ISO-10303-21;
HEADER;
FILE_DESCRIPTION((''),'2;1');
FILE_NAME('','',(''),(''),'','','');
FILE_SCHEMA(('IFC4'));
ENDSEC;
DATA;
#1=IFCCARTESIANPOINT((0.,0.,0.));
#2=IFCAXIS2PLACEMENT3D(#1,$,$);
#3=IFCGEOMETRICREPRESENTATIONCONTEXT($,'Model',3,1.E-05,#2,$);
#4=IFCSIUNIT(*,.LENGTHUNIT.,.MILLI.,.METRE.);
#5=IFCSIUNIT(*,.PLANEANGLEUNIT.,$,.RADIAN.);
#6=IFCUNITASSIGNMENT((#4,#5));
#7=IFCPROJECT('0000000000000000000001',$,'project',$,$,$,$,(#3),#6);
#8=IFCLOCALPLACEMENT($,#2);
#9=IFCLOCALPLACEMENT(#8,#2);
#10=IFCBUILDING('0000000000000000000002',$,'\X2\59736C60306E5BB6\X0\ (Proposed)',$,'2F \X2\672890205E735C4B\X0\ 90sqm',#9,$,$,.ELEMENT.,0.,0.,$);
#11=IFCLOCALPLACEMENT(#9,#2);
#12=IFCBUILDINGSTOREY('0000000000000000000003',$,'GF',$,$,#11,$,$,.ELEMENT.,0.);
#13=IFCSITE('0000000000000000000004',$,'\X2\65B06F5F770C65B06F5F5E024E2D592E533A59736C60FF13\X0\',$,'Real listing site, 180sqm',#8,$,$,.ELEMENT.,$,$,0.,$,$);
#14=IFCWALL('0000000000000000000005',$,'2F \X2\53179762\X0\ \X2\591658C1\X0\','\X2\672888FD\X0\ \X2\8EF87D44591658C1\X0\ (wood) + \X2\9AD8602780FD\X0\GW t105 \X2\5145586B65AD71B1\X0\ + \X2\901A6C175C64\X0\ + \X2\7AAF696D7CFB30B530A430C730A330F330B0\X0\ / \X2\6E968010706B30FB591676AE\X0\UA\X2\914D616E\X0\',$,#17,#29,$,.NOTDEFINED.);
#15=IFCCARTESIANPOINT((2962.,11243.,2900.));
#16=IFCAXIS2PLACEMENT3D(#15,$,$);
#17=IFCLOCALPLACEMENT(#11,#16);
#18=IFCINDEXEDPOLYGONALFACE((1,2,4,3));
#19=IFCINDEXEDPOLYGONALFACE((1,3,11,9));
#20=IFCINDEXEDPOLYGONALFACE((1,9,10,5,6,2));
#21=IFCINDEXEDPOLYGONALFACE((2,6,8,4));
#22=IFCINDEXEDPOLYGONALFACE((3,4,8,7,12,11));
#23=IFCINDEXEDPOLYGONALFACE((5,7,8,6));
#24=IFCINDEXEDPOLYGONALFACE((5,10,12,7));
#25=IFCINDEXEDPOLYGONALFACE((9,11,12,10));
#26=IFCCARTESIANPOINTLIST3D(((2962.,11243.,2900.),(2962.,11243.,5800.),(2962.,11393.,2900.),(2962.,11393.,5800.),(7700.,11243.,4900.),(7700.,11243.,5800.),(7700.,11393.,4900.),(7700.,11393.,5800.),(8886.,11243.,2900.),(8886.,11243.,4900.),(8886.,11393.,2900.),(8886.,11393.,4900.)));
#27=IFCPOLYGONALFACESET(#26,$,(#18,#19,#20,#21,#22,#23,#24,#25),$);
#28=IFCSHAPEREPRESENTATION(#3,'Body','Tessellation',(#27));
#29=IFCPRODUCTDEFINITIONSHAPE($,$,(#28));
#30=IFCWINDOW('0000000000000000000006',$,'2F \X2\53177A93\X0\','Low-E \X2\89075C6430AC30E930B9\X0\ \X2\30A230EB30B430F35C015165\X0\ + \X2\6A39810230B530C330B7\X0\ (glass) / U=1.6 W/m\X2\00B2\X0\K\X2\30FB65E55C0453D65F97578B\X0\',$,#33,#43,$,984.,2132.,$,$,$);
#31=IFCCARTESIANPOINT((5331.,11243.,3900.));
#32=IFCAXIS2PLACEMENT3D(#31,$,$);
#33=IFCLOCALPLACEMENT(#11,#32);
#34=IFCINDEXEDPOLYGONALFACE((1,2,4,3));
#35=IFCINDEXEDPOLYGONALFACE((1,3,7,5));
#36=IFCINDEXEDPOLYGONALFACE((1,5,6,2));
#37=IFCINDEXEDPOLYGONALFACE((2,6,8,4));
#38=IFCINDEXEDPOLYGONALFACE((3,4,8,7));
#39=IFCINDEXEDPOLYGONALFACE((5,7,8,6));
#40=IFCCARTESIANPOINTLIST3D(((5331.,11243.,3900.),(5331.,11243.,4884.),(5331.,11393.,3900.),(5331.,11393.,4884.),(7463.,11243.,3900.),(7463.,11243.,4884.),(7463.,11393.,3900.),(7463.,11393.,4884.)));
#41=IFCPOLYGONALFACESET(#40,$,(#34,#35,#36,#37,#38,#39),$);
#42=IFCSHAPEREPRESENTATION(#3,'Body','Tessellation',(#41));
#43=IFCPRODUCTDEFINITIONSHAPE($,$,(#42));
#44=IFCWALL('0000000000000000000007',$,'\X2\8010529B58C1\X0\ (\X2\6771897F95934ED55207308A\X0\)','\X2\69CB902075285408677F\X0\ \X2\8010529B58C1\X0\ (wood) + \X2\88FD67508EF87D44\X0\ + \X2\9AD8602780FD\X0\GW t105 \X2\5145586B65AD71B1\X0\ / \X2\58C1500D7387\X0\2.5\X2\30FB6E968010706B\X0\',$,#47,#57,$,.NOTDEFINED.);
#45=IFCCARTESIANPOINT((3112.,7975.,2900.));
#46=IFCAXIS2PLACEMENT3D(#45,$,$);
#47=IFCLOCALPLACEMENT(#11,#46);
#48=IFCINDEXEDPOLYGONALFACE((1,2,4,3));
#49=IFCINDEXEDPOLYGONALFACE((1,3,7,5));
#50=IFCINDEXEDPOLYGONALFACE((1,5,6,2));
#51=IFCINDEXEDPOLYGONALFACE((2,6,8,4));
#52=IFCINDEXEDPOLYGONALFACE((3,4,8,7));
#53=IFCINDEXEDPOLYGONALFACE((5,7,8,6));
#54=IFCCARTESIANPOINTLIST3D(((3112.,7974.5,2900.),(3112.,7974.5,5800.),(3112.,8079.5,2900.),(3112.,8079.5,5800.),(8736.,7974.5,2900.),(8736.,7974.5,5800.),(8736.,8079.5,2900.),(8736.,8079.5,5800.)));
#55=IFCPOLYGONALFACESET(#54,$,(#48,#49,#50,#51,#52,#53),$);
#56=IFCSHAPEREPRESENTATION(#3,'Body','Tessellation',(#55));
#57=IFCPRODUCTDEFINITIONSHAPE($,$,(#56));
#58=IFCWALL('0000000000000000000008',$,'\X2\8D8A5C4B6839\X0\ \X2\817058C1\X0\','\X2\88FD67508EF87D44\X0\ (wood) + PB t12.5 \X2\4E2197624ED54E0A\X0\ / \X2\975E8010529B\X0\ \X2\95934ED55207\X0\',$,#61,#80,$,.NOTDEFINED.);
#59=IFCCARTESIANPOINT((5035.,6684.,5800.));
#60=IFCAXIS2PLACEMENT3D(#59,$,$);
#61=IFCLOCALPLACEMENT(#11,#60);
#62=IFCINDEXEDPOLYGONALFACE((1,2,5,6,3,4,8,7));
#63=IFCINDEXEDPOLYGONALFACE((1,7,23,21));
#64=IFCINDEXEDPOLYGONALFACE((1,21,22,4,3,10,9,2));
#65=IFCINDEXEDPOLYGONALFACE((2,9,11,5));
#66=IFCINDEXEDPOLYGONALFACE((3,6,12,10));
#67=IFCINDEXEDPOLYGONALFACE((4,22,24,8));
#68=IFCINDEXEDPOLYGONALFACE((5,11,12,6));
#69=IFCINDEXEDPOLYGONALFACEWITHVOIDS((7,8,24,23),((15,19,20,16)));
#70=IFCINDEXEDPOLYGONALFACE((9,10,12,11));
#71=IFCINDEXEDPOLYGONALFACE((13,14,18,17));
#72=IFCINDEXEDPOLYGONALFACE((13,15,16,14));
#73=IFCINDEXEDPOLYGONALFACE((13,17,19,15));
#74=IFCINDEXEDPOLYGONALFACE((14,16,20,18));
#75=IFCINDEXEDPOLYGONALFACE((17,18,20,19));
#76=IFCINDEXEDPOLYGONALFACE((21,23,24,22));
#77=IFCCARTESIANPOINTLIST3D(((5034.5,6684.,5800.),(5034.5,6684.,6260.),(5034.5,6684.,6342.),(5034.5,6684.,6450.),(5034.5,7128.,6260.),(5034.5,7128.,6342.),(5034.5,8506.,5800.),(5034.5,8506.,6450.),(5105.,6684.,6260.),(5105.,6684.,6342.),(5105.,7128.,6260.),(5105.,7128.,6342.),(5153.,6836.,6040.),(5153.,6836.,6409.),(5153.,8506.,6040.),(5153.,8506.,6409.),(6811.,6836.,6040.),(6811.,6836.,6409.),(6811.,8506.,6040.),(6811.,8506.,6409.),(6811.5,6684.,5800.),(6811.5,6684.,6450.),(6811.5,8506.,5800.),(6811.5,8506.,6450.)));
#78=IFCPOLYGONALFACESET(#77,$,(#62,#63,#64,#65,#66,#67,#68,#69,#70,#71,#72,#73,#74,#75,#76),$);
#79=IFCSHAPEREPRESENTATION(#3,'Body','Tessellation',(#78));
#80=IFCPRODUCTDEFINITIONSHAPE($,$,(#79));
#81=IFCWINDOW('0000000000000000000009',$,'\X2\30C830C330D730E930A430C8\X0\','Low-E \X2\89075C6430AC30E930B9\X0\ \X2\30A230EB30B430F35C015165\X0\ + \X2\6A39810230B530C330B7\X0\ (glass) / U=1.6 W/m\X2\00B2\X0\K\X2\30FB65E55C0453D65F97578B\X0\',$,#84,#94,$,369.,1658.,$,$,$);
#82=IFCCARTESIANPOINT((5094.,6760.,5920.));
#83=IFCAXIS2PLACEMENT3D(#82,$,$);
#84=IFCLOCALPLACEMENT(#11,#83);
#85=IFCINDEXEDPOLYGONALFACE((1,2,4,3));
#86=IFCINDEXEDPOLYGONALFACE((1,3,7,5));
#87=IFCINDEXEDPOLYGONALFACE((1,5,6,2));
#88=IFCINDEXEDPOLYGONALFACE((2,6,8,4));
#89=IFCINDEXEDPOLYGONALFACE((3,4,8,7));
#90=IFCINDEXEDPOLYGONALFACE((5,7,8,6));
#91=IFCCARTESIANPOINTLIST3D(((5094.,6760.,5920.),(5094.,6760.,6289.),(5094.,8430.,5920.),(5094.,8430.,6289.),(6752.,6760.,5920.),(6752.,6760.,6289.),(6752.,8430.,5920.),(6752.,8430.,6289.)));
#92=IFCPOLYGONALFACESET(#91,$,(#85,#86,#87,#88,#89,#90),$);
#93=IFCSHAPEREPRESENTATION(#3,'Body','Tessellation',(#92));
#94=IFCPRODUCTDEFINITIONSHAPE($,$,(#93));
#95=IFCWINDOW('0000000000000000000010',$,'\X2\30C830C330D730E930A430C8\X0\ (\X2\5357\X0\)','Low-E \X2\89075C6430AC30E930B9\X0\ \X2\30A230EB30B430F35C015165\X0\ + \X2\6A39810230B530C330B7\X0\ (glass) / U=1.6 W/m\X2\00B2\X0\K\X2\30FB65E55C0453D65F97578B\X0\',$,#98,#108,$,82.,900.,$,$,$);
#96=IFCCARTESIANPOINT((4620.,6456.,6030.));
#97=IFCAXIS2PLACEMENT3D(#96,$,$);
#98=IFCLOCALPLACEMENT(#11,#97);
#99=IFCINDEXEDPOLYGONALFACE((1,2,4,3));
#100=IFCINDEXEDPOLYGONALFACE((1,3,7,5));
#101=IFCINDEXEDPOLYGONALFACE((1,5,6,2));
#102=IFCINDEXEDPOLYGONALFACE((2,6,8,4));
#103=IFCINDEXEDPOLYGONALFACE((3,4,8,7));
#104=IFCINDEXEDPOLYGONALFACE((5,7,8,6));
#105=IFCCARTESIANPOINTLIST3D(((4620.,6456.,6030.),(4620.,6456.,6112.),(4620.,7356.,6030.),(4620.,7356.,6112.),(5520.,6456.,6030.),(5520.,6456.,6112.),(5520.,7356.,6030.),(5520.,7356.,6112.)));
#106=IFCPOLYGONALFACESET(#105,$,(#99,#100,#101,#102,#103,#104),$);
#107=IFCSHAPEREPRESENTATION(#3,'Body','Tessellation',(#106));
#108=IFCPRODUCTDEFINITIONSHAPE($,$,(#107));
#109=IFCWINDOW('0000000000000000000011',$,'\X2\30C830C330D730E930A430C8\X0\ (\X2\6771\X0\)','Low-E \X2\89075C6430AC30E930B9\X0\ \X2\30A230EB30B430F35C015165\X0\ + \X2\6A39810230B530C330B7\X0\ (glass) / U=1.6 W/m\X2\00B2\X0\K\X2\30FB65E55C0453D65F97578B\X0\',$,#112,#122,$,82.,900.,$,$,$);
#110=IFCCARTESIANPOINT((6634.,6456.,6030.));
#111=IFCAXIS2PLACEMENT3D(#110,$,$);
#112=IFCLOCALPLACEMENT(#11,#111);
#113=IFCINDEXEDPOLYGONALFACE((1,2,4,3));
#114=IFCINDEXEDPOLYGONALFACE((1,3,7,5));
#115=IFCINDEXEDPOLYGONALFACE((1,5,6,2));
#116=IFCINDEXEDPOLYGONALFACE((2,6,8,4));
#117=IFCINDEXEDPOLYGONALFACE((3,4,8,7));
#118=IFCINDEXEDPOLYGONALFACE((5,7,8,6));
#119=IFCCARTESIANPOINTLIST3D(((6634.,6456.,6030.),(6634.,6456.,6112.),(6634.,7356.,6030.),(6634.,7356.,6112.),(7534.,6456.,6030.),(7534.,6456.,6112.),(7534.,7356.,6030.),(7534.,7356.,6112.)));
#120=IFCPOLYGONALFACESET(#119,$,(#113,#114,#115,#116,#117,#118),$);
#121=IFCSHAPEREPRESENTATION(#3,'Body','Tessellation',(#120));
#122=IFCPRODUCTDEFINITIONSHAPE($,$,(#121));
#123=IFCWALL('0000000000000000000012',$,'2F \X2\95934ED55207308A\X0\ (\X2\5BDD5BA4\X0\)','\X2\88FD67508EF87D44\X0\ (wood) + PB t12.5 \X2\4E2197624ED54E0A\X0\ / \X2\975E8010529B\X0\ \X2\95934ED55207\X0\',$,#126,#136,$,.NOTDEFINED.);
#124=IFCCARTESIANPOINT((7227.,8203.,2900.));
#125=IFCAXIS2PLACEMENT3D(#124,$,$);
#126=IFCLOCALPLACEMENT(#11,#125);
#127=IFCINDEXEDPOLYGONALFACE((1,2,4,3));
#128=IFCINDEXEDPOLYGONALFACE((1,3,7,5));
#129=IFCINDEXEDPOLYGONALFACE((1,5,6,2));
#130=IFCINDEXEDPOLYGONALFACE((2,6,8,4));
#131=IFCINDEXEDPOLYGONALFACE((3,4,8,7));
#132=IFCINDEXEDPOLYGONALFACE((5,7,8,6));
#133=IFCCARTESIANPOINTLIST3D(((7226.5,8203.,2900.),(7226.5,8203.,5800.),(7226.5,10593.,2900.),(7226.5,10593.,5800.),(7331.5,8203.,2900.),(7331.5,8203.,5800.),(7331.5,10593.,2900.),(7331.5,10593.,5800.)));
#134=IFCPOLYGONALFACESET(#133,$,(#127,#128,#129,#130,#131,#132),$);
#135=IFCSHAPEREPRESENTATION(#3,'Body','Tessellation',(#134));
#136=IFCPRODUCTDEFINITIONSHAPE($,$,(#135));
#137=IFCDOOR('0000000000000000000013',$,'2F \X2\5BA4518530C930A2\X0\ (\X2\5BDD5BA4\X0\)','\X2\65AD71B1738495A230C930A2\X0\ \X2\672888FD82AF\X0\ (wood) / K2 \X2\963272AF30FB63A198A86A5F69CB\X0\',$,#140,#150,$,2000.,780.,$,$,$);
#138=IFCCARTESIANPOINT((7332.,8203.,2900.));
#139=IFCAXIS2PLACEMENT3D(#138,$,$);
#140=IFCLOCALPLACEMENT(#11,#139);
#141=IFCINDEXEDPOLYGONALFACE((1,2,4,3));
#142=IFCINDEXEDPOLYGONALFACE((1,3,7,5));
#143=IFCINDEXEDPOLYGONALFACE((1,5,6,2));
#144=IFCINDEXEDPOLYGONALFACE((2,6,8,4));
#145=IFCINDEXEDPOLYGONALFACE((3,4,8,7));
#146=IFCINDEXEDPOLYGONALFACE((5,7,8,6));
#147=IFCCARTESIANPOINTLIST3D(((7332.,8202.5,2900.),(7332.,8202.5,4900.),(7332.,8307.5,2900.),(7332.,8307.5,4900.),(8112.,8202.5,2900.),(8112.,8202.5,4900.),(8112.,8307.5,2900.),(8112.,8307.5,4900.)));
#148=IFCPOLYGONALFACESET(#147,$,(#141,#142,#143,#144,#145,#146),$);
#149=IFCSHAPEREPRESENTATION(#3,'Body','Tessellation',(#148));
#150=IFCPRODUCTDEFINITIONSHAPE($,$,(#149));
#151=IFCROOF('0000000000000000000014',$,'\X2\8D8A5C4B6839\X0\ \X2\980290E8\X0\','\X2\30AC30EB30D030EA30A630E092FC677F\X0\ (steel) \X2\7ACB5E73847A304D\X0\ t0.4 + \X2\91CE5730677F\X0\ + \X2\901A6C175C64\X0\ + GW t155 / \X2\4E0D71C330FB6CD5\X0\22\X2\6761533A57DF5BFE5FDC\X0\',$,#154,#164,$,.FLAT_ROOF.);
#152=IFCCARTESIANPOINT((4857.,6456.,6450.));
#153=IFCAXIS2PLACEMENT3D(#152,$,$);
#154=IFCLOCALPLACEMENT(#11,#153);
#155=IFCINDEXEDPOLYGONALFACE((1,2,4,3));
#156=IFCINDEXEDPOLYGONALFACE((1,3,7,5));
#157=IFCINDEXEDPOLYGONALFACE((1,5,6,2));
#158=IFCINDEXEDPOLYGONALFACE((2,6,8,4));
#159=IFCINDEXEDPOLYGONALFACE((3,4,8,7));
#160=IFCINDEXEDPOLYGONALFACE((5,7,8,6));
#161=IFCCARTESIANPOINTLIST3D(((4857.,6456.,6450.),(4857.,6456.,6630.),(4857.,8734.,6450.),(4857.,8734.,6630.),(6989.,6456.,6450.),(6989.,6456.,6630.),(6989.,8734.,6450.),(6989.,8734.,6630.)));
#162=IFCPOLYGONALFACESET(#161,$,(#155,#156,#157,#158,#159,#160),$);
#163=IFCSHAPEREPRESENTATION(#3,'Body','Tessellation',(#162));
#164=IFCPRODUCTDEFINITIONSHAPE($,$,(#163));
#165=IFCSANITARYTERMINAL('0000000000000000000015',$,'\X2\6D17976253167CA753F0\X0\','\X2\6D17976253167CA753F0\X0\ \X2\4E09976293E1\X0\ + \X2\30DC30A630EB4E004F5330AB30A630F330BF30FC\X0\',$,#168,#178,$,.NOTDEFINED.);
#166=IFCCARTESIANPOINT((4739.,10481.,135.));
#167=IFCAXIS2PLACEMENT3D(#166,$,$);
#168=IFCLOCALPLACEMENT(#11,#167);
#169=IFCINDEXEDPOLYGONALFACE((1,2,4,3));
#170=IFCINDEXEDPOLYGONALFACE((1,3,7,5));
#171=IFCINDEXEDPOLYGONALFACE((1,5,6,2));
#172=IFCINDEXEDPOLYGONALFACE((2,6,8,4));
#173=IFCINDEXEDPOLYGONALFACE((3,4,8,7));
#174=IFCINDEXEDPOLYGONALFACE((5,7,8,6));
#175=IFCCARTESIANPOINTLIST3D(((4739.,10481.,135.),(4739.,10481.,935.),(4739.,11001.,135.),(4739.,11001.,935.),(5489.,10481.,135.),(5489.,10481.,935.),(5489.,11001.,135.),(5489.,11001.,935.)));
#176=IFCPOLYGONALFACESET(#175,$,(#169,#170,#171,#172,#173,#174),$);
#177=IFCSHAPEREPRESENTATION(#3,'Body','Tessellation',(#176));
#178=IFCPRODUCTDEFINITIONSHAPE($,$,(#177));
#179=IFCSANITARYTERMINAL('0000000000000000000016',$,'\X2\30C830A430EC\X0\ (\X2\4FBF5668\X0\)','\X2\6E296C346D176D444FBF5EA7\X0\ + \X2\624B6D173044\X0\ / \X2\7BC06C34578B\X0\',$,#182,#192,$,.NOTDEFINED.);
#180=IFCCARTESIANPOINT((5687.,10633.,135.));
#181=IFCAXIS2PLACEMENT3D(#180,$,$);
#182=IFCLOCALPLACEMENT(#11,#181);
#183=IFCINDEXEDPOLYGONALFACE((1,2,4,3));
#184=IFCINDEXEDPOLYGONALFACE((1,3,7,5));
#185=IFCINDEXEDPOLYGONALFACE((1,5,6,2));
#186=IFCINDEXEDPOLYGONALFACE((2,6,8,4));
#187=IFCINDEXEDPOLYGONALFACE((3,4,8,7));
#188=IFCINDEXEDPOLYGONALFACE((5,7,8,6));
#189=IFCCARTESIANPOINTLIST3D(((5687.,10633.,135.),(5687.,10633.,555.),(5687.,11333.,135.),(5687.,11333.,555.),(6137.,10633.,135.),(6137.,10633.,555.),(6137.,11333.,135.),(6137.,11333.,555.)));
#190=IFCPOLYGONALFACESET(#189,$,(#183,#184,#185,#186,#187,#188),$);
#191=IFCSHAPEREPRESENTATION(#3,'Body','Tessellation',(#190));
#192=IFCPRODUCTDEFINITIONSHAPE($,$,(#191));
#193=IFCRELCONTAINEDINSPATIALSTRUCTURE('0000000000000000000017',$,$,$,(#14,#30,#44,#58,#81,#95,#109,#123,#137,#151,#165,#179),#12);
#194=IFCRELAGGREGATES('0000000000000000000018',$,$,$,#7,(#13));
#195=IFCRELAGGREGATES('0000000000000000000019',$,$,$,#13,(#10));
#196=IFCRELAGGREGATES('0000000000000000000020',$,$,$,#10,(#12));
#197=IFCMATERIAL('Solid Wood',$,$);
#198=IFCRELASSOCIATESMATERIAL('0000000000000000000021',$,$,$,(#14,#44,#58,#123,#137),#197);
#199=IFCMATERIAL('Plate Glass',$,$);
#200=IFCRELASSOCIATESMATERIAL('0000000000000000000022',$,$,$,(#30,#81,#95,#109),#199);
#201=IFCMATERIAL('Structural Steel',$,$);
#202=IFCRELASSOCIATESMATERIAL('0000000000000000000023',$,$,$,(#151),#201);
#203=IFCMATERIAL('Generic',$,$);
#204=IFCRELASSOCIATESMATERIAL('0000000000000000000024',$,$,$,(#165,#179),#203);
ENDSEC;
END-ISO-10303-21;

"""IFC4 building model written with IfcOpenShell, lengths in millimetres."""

from ifc_helpers import new_model, si_unit, frame, frame_2d, origin, place, context, project, spatial, rectangle, extrude, material, element, fill, save


model = new_model("IFC4")

# Units and contexts
model_context = context("Model", 3, precision=1e-05, world=origin())
ifc_project = project(units=[si_unit("LENGTHUNIT", "METRE", prefix="MILLI"), si_unit("PLANEANGLEUNIT", "RADIAN")], contexts=[model_context])

# Site, building, storey
site_placement = place(None, origin())
site = spatial("IfcSite", under=ifc_project, at=site_placement, Name="新潟県新潟市中央区女池３", ObjectType="Real listing site, 180sqm", CompositionType="ELEMENT", RefElevation=0.0)
building_placement = place(site_placement, origin())
building = spatial("IfcBuilding", under=site, at=building_placement, Name="女池の家 (Proposed)", ObjectType="2F 木造平屋 90sqm", CompositionType="ELEMENT", ElevationOfRefHeight=0.0, ElevationOfTerrain=0.0)
storey_placement = place(building_placement, origin())
storey = spatial("IfcBuildingStorey", under=building, at=storey_placement, Name="GF", CompositionType="ELEMENT", Elevation=0.0)

# Wall, opening, window
ifc_material_1 = material(Name="Solid Wood")
wall_1_placement = place(storey_placement, frame((2962.0, 11243.0, 2900.0)))
wall_1 = element("IfcWall", 1, at=wall_1_placement, inside=storey, material=ifc_material_1, Name="2F 北面 外壁", Description="木製 軸組外壁 (wood) + 高性能GW t105 充填断熱 + 通気層 + 窯業系サイディング / 準耐火・外皮UA配慮", PredefinedType="NOTDEFINED", context=model_context, shape_type="SweptSolid", body=[
    extrude(rectangle(XDim=5924.0, YDim=150.0, at=frame_2d((2962.0, 75.0))), frame((2962.0, 11243.0, 2900.0)), (0.0, 0.0, 1.0), 2900.0),
])
opening_1_placement = place(storey_placement, frame((5331.0, 11243.0, 3900.0)))
opening_1 = element("IfcOpeningElement", 2, at=opening_1_placement, cuts=wall_1, PredefinedType="NOTDEFINED", context=model_context, shape_type="SweptSolid", body=[
    extrude(rectangle(XDim=2132.0, YDim=150.0, at=frame_2d((1066.0, 75.0))), frame((5331.0, 11243.0, 3900.0)), (0.0, 0.0, 1.0), 984.0),
])
ifc_material_2 = material(Name="Plate Glass")
window_1_placement = place(storey_placement, frame((5331.0, 11243.0, 3900.0)))
window_1 = element("IfcWindow", 3, at=window_1_placement, inside=storey, material=ifc_material_2, Name="2F 北窓", Description="Low-E 複層ガラス アルゴン封入 + 樹脂サッシ (glass) / U=1.6 W/m²K・日射取得型", OverallHeight=984.0, OverallWidth=2132.0, context=model_context, shape_type="SweptSolid", body=[
    extrude(rectangle(XDim=2132.0, YDim=150.0, at=frame_2d((1066.0, 75.0))), frame((5331.0, 11243.0, 3900.0)), (0.0, 0.0, 1.0), 984.0),
])
fill(opening_1, window_1)

# Wall
wall_2_placement = place(storey_placement, frame((3112.0, 7975.0, 2900.0)))
element("IfcWall", 4, at=wall_2_placement, inside=storey, material=ifc_material_1, Name="耐力壁 (東西間仕切り)", Description="構造用合板 耐力壁 (wood) + 製材軸組 + 高性能GW t105 充填断熱 / 壁倍率2.5・準耐火", PredefinedType="NOTDEFINED", context=model_context, shape_type="SweptSolid", body=[
    extrude(rectangle(XDim=5624.0, YDim=105.0, at=frame_2d((2812.0, 52.0))), frame((3112.0, 7975.0, 2900.0)), (0.0, 0.0, 1.0), 2900.0),
])

# Wall, openings, windows
wall_3_placement = place(storey_placement, frame((5035.0, 6684.0, 5800.0)))
wall_3 = element("IfcWall", 5, at=wall_3_placement, inside=storey, material=ifc_material_1, Name="越屋根 腰壁", Description="製材軸組 (wood) + PB t12.5 両面仕上 / 非耐力 間仕切", PredefinedType="NOTDEFINED", context=model_context, shape_type="SweptSolid", body=[
    extrude(rectangle(XDim=1777.0, YDim=1822.0, at=frame_2d((888.0, 911.0))), frame((5035.0, 6684.0, 5800.0)), (0.0, 0.0, 1.0), 650.0),
])
opening_2_placement = place(storey_placement, frame((5094.0, 6760.0, 5920.0)))
opening_2 = element("IfcOpeningElement", 6, at=opening_2_placement, cuts=wall_3, PredefinedType="NOTDEFINED", context=model_context, shape_type="SweptSolid", body=[
    extrude(rectangle(XDim=1658.0, YDim=1670.0, at=frame_2d((829.0, 835.0))), frame((5094.0, 6760.0, 5920.0)), (0.0, 0.0, 1.0), 369.0),
])
opening_3_placement = place(storey_placement, frame((4620.0, 6456.0, 6030.0)))
opening_3 = element("IfcOpeningElement", 7, at=opening_3_placement, cuts=wall_3, PredefinedType="NOTDEFINED", context=model_context, shape_type="SweptSolid", body=[
    extrude(rectangle(XDim=900.0, YDim=900.0, at=frame_2d((450.0, 450.0))), frame((4620.0, 6456.0, 6030.0)), (0.0, 0.0, 1.0), 82.0),
])
opening_4_placement = place(storey_placement, frame((6634.0, 6456.0, 6030.0)))
opening_4 = element("IfcOpeningElement", 8, at=opening_4_placement, cuts=wall_3, PredefinedType="NOTDEFINED", context=model_context, shape_type="SweptSolid", body=[
    extrude(rectangle(XDim=900.0, YDim=900.0, at=frame_2d((450.0, 450.0))), frame((6634.0, 6456.0, 6030.0)), (0.0, 0.0, 1.0), 82.0),
])
window_2_placement = place(storey_placement, frame((5094.0, 6760.0, 5920.0)))
window_2 = element("IfcWindow", 9, at=window_2_placement, inside=storey, material=ifc_material_2, Name="トップライト", Description="Low-E 複層ガラス アルゴン封入 + 樹脂サッシ (glass) / U=1.6 W/m²K・日射取得型", OverallHeight=369.0, OverallWidth=1658.0, context=model_context, shape_type="SweptSolid", body=[
    extrude(rectangle(XDim=1658.0, YDim=1670.0, at=frame_2d((829.0, 835.0))), frame((5094.0, 6760.0, 5920.0)), (0.0, 0.0, 1.0), 369.0),
])
fill(opening_2, window_2)
window_3_placement = place(storey_placement, frame((4620.0, 6456.0, 6030.0)))
window_3 = element("IfcWindow", 10, at=window_3_placement, inside=storey, material=ifc_material_2, Name="トップライト (南)", Description="Low-E 複層ガラス アルゴン封入 + 樹脂サッシ (glass) / U=1.6 W/m²K・日射取得型", OverallHeight=82.0, OverallWidth=900.0, context=model_context, shape_type="SweptSolid", body=[
    extrude(rectangle(XDim=900.0, YDim=900.0, at=frame_2d((450.0, 450.0))), frame((4620.0, 6456.0, 6030.0)), (0.0, 0.0, 1.0), 82.0),
])
fill(opening_3, window_3)
window_4_placement = place(storey_placement, frame((6634.0, 6456.0, 6030.0)))
window_4 = element("IfcWindow", 11, at=window_4_placement, inside=storey, material=ifc_material_2, Name="トップライト (東)", Description="Low-E 複層ガラス アルゴン封入 + 樹脂サッシ (glass) / U=1.6 W/m²K・日射取得型", OverallHeight=82.0, OverallWidth=900.0, context=model_context, shape_type="SweptSolid", body=[
    extrude(rectangle(XDim=900.0, YDim=900.0, at=frame_2d((450.0, 450.0))), frame((6634.0, 6456.0, 6030.0)), (0.0, 0.0, 1.0), 82.0),
])
fill(opening_4, window_4)

# Wall
wall_4_placement = place(storey_placement, frame((7227.0, 8203.0, 2900.0)))
element("IfcWall", 12, at=wall_4_placement, inside=storey, material=ifc_material_1, Name="2F 間仕切り (寝室)", Description="製材軸組 (wood) + PB t12.5 両面仕上 / 非耐力 間仕切", PredefinedType="NOTDEFINED", context=model_context, shape_type="SweptSolid", body=[
    extrude(rectangle(XDim=105.0, YDim=2390.0, at=frame_2d((52.0, 1195.0))), frame((7227.0, 8203.0, 2900.0)), (0.0, 0.0, 1.0), 2900.0),
])

# Door
door_placement = place(storey_placement, frame((7332.0, 8203.0, 2900.0)))
element("IfcDoor", 13, at=door_placement, inside=storey, material=ifc_material_1, Name="2F 室内ドア (寝室)", Description="断熱玄関ドア 木製芯 (wood) / K2 防犯・採風機構", OverallHeight=2000.0, OverallWidth=780.0, context=model_context, shape_type="SweptSolid", body=[
    extrude(rectangle(XDim=780.0, YDim=105.0, at=frame_2d((390.0, 52.0))), frame((7332.0, 8203.0, 2900.0)), (0.0, 0.0, 1.0), 2000.0),
])

# Roof
ifc_material_3 = material(Name="Structural Steel")
roof_placement = place(storey_placement, frame((4857.0, 6456.0, 6450.0)))
element("IfcRoof", 14, at=roof_placement, inside=storey, material=ifc_material_3, Name="越屋根 頂部", Description="ガルバリウム鋼板 (steel) 立平葺き t0.4 + 野地板 + 通気層 + GW t155 / 不燃・法22条区域対応", PredefinedType="FLAT_ROOF", context=model_context, shape_type="SweptSolid", body=[
    extrude(rectangle(XDim=2132.0, YDim=2278.0, at=frame_2d((1066.0, 1139.0))), frame((4857.0, 6456.0, 6450.0)), (0.0, 0.0, 1.0), 180.0),
])

# Sanitary terminals
ifc_material_4 = material(Name="Generic")
sanitary_terminal_1_placement = place(storey_placement, frame((4739.0, 10481.0, 135.0)))
element("IfcSanitaryTerminal", 15, at=sanitary_terminal_1_placement, inside=storey, material=ifc_material_4, Name="洗面化粧台", Description="洗面化粧台 三面鏡 + ボウル一体カウンター", PredefinedType="NOTDEFINED", context=model_context, shape_type="SweptSolid", body=[
    extrude(rectangle(XDim=750.0, YDim=520.0, at=frame_2d((375.0, 260.0))), frame((4739.0, 10481.0, 135.0)), (0.0, 0.0, 1.0), 800.0),
])
sanitary_terminal_2_placement = place(storey_placement, frame((5687.0, 10633.0, 135.0)))
element("IfcSanitaryTerminal", 16, at=sanitary_terminal_2_placement, inside=storey, material=ifc_material_4, Name="トイレ (便器)", Description="温水洗浄便座 + 手洗い / 節水型", PredefinedType="NOTDEFINED", context=model_context, shape_type="SweptSolid", body=[
    extrude(rectangle(XDim=450.0, YDim=700.0, at=frame_2d((225.0, 350.0))), frame((5687.0, 10633.0, 135.0)), (0.0, 0.0, 1.0), 420.0),
])

save(model, "model.ifc")
